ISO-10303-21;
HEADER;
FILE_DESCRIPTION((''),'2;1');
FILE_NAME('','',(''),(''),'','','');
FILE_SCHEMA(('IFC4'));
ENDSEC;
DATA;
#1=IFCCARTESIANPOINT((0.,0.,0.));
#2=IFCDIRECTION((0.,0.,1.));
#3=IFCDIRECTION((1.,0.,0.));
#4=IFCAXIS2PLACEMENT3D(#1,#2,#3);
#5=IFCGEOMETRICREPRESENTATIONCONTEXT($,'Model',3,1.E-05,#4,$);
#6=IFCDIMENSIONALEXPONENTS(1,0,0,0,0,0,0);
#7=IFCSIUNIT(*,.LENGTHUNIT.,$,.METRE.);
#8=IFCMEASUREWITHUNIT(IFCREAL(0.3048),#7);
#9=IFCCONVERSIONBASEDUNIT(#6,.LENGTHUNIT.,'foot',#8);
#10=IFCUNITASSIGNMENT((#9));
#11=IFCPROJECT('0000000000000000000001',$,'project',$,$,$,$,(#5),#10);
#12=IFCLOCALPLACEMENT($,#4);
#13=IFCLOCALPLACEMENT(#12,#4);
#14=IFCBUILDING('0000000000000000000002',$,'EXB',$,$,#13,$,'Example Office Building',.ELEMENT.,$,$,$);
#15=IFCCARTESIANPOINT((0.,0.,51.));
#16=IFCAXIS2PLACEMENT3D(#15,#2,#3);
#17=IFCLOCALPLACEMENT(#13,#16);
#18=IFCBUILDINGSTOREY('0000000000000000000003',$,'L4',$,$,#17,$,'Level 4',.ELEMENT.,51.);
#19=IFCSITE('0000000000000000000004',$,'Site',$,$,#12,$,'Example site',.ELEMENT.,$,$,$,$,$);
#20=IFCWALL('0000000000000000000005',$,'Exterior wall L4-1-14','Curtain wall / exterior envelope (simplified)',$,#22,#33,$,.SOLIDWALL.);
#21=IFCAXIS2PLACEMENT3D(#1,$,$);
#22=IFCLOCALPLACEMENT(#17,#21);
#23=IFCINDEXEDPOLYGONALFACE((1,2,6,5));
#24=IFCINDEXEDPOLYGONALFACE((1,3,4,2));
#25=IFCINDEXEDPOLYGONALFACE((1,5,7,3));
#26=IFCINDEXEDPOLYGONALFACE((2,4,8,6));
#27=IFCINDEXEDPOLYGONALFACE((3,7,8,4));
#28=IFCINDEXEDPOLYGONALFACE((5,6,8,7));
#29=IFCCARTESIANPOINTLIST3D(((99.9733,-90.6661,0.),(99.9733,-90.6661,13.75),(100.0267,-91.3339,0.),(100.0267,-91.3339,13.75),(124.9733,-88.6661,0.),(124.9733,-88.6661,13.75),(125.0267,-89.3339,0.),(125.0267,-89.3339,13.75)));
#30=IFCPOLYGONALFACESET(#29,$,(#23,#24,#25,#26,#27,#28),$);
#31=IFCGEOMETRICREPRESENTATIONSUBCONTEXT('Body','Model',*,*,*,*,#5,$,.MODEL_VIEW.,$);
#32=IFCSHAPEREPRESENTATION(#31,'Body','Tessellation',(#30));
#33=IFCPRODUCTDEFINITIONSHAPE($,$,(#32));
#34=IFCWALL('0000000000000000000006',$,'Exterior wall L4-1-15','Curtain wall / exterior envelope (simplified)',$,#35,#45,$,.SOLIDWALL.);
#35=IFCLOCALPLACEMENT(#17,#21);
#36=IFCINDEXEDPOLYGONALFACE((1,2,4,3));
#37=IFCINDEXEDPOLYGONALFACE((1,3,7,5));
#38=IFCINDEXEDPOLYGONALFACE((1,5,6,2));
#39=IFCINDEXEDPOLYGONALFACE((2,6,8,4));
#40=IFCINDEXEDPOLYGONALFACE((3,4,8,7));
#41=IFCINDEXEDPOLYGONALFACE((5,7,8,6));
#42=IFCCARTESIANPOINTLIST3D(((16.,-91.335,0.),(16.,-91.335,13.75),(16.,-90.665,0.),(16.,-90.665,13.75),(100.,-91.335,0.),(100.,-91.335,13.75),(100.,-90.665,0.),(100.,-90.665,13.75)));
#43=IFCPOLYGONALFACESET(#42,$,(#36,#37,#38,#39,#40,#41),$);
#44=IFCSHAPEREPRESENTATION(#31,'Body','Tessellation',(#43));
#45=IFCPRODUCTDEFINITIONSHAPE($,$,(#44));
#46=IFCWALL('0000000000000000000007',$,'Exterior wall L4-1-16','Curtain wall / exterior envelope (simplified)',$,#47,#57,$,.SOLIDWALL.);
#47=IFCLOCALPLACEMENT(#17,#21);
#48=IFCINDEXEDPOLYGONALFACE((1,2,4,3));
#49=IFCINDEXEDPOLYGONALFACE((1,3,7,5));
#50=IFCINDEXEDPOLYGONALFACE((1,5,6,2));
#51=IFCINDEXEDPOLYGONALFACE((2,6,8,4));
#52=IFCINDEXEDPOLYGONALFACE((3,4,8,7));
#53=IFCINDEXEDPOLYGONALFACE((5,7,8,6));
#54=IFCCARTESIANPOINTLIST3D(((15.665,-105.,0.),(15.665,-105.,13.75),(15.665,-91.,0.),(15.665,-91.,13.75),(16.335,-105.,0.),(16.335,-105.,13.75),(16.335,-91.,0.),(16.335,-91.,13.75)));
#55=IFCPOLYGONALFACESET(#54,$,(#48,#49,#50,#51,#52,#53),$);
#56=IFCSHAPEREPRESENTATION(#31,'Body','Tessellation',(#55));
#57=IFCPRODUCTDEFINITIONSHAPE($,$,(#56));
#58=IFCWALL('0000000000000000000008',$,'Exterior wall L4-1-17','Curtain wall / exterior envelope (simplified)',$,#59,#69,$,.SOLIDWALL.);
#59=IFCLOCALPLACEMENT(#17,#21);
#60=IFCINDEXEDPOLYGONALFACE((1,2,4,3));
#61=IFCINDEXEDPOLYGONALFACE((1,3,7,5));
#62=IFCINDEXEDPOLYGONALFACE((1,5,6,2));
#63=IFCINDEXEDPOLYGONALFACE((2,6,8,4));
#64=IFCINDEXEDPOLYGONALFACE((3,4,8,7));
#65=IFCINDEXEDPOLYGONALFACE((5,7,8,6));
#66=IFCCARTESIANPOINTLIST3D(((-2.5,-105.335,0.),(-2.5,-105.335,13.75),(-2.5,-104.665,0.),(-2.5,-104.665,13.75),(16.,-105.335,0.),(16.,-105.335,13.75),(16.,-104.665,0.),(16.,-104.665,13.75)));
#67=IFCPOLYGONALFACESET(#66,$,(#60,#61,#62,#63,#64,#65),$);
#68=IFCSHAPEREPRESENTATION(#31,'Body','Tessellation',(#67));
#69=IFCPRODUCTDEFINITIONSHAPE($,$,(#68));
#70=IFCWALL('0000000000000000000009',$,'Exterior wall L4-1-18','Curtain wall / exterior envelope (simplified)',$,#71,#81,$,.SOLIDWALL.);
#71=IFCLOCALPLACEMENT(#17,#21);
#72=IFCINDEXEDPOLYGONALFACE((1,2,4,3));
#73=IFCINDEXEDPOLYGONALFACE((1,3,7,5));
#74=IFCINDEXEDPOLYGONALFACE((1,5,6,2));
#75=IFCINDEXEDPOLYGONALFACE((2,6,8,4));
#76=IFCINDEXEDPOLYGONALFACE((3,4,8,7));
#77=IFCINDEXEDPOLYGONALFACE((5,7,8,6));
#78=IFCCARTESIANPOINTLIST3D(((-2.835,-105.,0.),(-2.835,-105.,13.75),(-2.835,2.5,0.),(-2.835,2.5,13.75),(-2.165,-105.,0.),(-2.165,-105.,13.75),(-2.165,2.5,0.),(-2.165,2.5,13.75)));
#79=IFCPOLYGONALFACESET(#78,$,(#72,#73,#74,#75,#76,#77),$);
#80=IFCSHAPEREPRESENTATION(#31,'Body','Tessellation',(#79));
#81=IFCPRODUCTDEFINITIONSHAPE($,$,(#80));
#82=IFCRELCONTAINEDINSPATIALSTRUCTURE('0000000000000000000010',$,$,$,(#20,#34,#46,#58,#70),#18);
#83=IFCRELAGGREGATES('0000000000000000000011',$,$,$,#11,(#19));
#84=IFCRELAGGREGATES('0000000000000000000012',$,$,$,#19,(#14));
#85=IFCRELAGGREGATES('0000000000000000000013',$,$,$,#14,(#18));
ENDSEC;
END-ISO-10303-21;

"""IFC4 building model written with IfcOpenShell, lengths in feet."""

from ifc_helpers import new_model, entity, si_unit, converted_unit, frame, frame_2d, origin, origin_with_axes, place, context, subcontext, project, spatial, rectangle, extrude, element, save


model = new_model("IFC4")

# Units and contexts
model_context = context("Model", 3, precision=1e-05, world=origin_with_axes())
body_context = subcontext(model_context, "Body", "Model", "MODEL_VIEW")
ifc_project = project(units=[converted_unit("LENGTHUNIT", "foot", entity("IfcReal", 0.3048), si_unit("LENGTHUNIT", "METRE"), dimensions=[1, 0, 0, 0, 0, 0, 0])], contexts=[model_context])

# Site, building, storey
site_placement = place(None, origin_with_axes())
site = spatial("IfcSite", under=ifc_project, at=site_placement, Name="Site", LongName="Example site", CompositionType="ELEMENT")
building_placement = place(site_placement, origin_with_axes())
building = spatial("IfcBuilding", under=site, at=building_placement, Name="EXB", LongName="Example Office Building", CompositionType="ELEMENT")
storey_placement = place(building_placement, frame((0.0, 0.0, 51.0), z_axis=(0.0, 0.0, 1.0), x_axis=(1.0, 0.0, 0.0)))
storey = spatial("IfcBuildingStorey", under=building, at=storey_placement, Name="L4", LongName="Level 4", CompositionType="ELEMENT", Elevation=51.0)

# Walls
wall_1_placement = place(storey_placement, frame((125.0, -89.0, 0.0), z_axis=(0.0, 0.0, 1.0), x_axis=(-0.996815, -0.079745, 0.0)))
element("IfcWall", 1, at=wall_1_placement, inside=storey, Name="Exterior wall L4-1-14", Description="Curtain wall / exterior envelope (simplified)", PredefinedType="SOLIDWALL", context=body_context, shape_type="SweptSolid", body=[
    extrude(rectangle(XDim=25.0799, YDim=0.67, at=frame_2d((12.5399, 0.0))), origin(), (0.0, 0.0, 1.0), 13.75),
])
wall_2_placement = place(storey_placement, frame((100.0, -91.0, 0.0), z_axis=(0.0, 0.0, 1.0), x_axis=(-1.0, 0.0, 0.0)))
element("IfcWall", 2, at=wall_2_placement, inside=storey, Name="Exterior wall L4-1-15", Description="Curtain wall / exterior envelope (simplified)", PredefinedType="SOLIDWALL", context=body_context, shape_type="SweptSolid", body=[
    extrude(rectangle(XDim=84.0, YDim=0.67, at=frame_2d((42.0, 0.0))), origin(), (0.0, 0.0, 1.0), 13.75),
])
wall_3_placement = place(storey_placement, frame((16.0, -91.0, 0.0), z_axis=(0.0, 0.0, 1.0), x_axis=(0.0, -1.0, 0.0)))
element("IfcWall", 3, at=wall_3_placement, inside=storey, Name="Exterior wall L4-1-16", Description="Curtain wall / exterior envelope (simplified)", PredefinedType="SOLIDWALL", context=body_context, shape_type="SweptSolid", body=[
    extrude(rectangle(XDim=14.0, YDim=0.67, at=frame_2d((7.0, 0.0))), origin(), (0.0, 0.0, 1.0), 13.75),
])
wall_4_placement = place(storey_placement, frame((16.0, -105.0, 0.0), z_axis=(0.0, 0.0, 1.0), x_axis=(-1.0, 0.0, 0.0)))
element("IfcWall", 4, at=wall_4_placement, inside=storey, Name="Exterior wall L4-1-17", Description="Curtain wall / exterior envelope (simplified)", PredefinedType="SOLIDWALL", context=body_context, shape_type="SweptSolid", body=[
    extrude(rectangle(XDim=18.5, YDim=0.67, at=frame_2d((9.25, 0.0))), origin(), (0.0, 0.0, 1.0), 13.75),
])
wall_5_placement = place(storey_placement, frame((-2.5, -105.0, 0.0), z_axis=(0.0, 0.0, 1.0), x_axis=(0.0, 1.0, 0.0)))
element("IfcWall", 5, at=wall_5_placement, inside=storey, Name="Exterior wall L4-1-18", Description="Curtain wall / exterior envelope (simplified)", PredefinedType="SOLIDWALL", context=body_context, shape_type="SweptSolid", body=[
    extrude(rectangle(XDim=107.5, YDim=0.67, at=frame_2d((53.75, 0.0))), origin(), (0.0, 0.0, 1.0), 13.75),
])

save(model, "model.ifc")
